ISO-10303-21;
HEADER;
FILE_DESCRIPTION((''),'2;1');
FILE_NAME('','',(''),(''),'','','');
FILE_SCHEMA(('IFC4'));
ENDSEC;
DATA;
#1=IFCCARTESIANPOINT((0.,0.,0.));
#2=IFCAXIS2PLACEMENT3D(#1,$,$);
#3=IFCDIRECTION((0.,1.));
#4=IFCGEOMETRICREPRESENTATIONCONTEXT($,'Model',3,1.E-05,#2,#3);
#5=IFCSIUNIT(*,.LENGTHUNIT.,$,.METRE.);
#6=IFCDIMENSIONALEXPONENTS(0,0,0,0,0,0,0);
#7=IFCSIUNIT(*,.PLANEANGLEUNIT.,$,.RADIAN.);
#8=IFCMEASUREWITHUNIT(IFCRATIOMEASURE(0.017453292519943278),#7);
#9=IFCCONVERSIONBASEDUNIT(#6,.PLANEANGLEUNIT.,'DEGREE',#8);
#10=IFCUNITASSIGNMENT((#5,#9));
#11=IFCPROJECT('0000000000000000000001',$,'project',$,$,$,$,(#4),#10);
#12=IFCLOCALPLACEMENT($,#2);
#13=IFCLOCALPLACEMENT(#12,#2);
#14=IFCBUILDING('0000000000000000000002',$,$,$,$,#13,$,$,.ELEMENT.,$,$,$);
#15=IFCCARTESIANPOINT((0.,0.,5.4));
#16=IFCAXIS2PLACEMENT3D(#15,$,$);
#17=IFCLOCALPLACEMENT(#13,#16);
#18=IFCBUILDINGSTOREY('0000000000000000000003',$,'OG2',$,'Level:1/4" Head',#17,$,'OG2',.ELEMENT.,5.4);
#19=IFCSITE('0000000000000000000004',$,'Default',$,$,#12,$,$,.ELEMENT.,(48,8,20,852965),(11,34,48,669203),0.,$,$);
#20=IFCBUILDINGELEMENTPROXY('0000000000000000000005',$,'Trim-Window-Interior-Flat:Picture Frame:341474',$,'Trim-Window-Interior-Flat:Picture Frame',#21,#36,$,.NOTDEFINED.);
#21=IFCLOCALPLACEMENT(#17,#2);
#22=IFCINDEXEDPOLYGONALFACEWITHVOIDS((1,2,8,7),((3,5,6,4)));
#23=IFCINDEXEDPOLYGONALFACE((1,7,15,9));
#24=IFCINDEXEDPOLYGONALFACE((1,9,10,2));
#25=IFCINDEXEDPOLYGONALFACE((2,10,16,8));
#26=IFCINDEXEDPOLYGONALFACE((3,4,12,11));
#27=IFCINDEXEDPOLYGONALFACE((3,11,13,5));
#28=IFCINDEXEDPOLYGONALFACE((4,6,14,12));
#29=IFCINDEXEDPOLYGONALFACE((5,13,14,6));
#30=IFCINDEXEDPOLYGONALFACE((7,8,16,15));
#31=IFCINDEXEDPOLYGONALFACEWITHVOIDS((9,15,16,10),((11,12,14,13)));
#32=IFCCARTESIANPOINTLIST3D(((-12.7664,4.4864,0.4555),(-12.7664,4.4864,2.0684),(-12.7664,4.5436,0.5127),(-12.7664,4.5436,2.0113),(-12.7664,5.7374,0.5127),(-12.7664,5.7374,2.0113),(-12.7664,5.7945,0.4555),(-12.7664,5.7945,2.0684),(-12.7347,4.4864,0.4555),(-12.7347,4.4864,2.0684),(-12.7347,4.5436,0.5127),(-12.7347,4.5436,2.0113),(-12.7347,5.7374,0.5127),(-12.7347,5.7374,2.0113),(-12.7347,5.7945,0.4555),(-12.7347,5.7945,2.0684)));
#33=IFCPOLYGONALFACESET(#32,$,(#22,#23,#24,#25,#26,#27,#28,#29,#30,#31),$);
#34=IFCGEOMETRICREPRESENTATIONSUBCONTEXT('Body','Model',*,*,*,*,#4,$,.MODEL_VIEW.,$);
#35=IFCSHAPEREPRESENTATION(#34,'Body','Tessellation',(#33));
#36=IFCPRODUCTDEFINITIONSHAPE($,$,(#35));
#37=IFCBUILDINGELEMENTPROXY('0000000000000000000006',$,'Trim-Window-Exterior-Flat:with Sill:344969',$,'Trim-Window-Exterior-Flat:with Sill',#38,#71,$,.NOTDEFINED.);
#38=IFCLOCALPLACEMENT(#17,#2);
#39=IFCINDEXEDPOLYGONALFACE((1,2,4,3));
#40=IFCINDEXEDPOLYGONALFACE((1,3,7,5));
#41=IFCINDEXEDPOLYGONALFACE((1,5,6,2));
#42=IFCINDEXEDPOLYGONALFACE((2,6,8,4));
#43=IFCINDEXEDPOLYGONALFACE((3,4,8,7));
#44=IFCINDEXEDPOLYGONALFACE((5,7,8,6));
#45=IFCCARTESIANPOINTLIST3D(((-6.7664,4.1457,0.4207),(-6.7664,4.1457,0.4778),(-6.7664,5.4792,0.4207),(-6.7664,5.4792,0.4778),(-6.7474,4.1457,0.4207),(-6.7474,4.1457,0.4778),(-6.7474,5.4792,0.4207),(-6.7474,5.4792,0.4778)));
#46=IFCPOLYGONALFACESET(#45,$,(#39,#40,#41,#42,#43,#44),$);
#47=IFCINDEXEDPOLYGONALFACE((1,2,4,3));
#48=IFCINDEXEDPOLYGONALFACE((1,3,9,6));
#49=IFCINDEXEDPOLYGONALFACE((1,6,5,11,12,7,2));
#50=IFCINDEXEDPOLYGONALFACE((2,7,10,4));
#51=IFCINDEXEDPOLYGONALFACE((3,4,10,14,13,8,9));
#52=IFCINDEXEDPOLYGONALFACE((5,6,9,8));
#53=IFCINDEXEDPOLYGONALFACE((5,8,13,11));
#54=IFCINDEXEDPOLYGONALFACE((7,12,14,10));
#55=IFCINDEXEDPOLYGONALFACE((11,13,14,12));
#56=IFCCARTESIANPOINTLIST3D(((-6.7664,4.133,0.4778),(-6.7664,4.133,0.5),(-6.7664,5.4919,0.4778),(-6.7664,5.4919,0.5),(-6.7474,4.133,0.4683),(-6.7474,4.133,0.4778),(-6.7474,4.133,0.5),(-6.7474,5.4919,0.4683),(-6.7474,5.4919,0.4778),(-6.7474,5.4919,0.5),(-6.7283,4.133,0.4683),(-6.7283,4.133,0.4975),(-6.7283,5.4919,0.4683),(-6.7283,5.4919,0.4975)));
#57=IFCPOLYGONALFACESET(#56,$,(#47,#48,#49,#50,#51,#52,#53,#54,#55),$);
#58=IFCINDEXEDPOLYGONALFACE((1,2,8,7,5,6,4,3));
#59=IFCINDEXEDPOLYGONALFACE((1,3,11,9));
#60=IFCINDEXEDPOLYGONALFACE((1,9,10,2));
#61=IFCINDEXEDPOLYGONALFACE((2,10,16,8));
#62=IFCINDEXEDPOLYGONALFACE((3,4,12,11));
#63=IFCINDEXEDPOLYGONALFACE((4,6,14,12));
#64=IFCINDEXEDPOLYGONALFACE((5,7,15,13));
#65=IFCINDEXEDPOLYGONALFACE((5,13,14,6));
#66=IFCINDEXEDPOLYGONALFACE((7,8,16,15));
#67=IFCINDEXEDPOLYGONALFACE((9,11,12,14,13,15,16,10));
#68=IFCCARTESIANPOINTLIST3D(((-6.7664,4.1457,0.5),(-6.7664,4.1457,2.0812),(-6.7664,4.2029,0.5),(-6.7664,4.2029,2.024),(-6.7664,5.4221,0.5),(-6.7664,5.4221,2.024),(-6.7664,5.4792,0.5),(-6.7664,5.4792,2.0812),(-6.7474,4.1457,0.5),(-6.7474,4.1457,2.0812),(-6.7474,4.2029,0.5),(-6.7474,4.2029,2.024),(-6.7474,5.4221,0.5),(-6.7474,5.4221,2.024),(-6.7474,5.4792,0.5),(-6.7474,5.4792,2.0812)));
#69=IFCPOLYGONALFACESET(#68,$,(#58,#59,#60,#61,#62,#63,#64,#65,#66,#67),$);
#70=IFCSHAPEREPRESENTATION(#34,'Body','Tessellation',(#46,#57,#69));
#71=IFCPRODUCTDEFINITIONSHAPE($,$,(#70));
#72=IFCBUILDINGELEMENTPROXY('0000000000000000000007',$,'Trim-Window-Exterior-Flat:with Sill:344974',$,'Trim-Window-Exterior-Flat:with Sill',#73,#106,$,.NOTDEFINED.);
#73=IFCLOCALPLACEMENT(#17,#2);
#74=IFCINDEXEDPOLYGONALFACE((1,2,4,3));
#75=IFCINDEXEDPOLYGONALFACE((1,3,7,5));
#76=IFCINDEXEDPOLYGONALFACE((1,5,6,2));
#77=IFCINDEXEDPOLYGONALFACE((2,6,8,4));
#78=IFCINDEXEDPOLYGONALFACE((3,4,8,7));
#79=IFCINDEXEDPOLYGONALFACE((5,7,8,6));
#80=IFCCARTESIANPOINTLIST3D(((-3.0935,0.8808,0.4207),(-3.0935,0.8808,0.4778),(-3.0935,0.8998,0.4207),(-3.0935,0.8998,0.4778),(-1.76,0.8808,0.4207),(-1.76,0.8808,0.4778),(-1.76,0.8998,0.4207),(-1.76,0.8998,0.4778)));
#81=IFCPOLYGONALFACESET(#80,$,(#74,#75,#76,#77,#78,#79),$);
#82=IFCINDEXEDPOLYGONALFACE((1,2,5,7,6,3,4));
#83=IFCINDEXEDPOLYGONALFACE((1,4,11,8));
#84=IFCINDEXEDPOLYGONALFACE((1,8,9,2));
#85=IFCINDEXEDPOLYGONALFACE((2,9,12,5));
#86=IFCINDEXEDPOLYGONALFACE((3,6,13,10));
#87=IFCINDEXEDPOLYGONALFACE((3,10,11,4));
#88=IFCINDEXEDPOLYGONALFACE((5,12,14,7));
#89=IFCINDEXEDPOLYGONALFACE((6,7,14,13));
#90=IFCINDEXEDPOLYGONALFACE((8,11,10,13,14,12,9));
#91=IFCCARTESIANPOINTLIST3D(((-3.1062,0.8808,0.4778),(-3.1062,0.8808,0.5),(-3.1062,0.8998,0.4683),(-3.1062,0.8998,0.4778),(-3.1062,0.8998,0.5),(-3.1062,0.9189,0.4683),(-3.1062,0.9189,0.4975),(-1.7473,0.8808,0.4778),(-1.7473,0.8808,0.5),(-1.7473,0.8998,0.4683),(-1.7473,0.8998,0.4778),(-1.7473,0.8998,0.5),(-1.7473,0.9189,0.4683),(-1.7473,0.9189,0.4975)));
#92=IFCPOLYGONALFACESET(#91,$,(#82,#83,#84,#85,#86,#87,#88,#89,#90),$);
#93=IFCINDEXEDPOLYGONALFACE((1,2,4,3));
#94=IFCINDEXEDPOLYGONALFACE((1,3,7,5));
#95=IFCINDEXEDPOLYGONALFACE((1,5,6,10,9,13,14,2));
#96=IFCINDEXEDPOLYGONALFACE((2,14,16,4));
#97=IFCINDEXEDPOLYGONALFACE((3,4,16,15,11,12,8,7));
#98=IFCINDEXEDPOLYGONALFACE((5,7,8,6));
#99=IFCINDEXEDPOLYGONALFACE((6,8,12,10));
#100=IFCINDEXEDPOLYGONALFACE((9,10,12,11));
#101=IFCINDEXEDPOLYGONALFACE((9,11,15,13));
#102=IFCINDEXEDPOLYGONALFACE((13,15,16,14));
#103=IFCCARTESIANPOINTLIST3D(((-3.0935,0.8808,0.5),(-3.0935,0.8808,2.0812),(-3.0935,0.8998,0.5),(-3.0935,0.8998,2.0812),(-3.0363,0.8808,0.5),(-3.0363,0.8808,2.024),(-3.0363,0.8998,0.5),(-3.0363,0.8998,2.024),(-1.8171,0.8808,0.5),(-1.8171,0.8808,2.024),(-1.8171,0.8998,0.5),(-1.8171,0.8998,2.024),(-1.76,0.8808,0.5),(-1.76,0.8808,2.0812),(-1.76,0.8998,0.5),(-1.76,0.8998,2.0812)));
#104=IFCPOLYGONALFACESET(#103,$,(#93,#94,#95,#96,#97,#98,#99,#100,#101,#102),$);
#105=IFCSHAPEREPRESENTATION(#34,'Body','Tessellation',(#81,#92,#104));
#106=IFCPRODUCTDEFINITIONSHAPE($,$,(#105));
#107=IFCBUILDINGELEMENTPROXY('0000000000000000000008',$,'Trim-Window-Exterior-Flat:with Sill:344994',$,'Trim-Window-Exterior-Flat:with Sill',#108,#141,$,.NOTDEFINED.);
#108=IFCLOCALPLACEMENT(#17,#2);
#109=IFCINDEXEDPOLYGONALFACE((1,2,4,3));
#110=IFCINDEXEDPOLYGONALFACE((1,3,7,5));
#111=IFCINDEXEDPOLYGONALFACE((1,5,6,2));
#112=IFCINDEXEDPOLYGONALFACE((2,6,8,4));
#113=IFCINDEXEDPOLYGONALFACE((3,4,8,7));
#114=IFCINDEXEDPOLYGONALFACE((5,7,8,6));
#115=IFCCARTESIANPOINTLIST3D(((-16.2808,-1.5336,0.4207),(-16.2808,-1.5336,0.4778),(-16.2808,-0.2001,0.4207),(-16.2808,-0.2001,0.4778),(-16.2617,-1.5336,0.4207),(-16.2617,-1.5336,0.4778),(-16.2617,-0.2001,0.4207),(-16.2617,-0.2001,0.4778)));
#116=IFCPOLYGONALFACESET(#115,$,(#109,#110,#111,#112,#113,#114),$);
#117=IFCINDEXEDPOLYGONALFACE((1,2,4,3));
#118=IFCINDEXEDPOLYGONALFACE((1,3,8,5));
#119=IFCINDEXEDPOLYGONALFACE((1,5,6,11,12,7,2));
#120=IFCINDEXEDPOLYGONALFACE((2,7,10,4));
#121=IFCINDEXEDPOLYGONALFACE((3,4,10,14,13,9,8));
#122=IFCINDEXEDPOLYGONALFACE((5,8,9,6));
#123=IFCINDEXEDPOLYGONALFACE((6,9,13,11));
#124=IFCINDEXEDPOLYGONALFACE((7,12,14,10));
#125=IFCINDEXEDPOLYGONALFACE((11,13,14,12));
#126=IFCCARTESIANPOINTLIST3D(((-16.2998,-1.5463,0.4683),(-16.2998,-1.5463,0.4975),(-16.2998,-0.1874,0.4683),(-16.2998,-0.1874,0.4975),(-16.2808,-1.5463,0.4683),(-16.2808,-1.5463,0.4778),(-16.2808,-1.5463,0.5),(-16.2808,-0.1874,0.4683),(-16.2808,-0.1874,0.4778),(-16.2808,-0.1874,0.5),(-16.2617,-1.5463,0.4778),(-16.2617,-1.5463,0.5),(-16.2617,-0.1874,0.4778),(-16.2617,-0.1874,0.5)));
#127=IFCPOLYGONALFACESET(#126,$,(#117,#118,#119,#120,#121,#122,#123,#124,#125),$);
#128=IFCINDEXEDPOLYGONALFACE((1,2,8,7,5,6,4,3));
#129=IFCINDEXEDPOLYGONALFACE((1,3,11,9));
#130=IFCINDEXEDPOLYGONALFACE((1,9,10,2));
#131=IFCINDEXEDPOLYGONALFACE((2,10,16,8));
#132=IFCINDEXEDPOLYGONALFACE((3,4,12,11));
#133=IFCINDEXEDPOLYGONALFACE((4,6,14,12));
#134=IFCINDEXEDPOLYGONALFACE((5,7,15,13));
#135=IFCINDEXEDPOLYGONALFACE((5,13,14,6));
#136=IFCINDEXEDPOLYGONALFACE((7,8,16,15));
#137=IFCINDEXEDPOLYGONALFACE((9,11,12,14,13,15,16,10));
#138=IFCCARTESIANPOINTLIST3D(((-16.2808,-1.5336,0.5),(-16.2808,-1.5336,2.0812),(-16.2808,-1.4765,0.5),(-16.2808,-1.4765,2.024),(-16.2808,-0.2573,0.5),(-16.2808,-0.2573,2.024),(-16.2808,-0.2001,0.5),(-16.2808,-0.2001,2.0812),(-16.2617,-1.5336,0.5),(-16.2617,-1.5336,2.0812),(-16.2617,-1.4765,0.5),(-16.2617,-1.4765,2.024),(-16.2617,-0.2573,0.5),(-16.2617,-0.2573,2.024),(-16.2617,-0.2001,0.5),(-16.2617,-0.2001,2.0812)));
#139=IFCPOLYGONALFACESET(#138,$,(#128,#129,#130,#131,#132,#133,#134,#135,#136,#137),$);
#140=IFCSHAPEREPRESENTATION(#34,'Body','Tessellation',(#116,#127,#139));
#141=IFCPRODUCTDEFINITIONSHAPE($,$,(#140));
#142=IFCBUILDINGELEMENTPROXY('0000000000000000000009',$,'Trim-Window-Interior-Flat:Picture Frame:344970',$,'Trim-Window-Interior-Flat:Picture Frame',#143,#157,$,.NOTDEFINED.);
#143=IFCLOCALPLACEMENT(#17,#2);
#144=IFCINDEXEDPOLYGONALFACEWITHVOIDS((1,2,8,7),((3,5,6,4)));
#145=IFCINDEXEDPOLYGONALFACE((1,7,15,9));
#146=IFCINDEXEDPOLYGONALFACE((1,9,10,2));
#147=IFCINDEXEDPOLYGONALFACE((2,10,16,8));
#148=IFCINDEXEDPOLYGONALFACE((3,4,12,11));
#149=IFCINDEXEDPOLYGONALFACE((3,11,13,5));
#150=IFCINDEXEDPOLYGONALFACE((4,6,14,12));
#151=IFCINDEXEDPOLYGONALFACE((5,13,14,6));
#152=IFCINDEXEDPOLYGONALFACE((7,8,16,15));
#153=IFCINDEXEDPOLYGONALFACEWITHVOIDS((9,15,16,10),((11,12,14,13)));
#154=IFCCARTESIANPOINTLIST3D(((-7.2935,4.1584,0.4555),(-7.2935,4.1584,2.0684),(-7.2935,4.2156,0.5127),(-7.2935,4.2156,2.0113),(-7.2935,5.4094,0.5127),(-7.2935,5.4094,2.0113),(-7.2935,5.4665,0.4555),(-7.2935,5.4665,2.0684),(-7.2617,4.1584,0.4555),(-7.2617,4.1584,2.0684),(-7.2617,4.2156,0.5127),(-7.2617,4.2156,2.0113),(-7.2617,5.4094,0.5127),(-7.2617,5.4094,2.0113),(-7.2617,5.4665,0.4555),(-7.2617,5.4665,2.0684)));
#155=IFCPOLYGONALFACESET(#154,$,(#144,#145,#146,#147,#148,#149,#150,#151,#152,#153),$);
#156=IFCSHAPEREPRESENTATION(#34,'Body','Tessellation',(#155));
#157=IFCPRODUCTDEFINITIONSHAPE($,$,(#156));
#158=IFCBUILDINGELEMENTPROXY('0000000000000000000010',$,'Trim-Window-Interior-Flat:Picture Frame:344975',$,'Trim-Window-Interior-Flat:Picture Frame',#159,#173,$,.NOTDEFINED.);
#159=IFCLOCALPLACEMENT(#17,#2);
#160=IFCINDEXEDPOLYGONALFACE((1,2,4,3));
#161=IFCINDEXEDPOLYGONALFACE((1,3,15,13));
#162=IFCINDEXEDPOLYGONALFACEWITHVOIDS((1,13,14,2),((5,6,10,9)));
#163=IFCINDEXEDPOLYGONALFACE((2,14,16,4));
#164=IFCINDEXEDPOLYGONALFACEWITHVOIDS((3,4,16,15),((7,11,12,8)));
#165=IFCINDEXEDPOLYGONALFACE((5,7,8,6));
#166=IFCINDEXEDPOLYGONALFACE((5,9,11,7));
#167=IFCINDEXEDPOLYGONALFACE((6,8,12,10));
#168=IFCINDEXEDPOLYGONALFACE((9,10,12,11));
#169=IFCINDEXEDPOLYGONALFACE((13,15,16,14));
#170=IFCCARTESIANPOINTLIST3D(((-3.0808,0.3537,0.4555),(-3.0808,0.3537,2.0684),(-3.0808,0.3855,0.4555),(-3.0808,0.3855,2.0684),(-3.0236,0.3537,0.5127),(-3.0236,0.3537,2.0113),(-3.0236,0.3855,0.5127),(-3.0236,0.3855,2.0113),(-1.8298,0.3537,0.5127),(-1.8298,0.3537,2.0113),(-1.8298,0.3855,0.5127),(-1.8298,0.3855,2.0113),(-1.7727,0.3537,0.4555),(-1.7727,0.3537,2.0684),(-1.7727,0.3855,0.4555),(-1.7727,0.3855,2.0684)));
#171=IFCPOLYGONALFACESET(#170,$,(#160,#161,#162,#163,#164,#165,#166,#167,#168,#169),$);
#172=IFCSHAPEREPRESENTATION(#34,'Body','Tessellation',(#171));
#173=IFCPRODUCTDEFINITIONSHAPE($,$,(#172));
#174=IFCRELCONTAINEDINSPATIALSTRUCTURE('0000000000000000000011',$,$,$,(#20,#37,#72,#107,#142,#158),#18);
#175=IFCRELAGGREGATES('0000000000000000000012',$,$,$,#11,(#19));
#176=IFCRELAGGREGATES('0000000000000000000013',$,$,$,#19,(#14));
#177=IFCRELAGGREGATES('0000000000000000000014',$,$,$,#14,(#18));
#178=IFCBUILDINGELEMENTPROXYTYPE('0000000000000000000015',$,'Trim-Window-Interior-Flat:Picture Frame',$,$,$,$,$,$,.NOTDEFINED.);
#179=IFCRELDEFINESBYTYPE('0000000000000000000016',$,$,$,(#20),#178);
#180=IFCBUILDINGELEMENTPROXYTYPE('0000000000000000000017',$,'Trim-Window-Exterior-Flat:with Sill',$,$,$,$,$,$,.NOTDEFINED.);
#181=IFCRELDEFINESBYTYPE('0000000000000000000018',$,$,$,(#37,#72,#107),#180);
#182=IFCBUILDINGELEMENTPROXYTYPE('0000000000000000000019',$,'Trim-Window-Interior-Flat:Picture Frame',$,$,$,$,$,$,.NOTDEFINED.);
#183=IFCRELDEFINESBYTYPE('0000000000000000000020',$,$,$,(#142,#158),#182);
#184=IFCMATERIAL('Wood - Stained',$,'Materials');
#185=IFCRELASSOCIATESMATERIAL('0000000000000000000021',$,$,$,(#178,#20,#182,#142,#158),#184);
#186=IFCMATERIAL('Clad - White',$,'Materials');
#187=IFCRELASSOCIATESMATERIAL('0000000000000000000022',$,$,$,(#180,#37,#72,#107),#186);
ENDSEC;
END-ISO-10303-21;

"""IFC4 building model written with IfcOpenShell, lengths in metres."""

from ifc_helpers import new_model, entity, si_unit, converted_unit, direction, frame, origin, place, context, subcontext, project, spatial, indexed_curve, outline, extrude, source, transform, mapped, material, type_object, type_shapes, element, save


model = new_model("IFC4")

# Units and contexts
model_context = context("Model", 3, precision=1e-05, world=origin(), true_north=direction((0.0, 1.0)))
body_context = subcontext(model_context, "Body", "Model", "MODEL_VIEW")
ifc_project = project(units=[si_unit("LENGTHUNIT", "METRE"), converted_unit("PLANEANGLEUNIT", "DEGREE", entity("IfcRatioMeasure", 0.017453292519943278), si_unit("PLANEANGLEUNIT", "RADIAN"), dimensions=[0, 0, 0, 0, 0, 0, 0])], contexts=[model_context])

# Site, building, storey
site_placement = place(None, origin())
site = spatial("IfcSite", under=ifc_project, at=site_placement, Name="Default", CompositionType="ELEMENT", RefLatitude=(48, 8, 20, 852965), RefLongitude=(11, 34, 48, 669203), RefElevation=0.0)
building_placement = place(site_placement, origin())
building = spatial("IfcBuilding", under=site, at=building_placement, CompositionType="ELEMENT")
storey_placement = place(building_placement, frame((0.0, 0.0, 5.4)))
storey = spatial("IfcBuildingStorey", under=building, at=storey_placement, Name="OG2", ObjectType="Level:1/4\" Head", LongName="OG2", CompositionType="ELEMENT", Elevation=5.4)

# Building element proxies
ifc_material_1 = material(Name="Clad - White", Category="Materials")
ifc_material_2 = material(Name="Wood - Stained", Category="Materials")
building_element_proxy_type_1 = type_object("IfcBuildingElementProxyType", Name="Trim-Window-Interior-Flat:Picture Frame", PredefinedType="NOTDEFINED", material=ifc_material_2)
shared_shape_1 = source(origin(), body_context, "Body", "SweptSolid", [
    extrude(outline(indexed_curve([(-0.8064, -0.654), (0.8064, -0.654), (0.8064, 0.654), (-0.8064, 0.654), (-0.8064, -0.654)], self_intersect=False), holes=[indexed_curve([(-0.7493, -0.5969), (-0.7493, 0.5969), (0.7493, 0.5969), (0.7493, -0.5969), (-0.7493, -0.5969)], self_intersect=False)]), frame((0.0, 0.762, 0.0), z_axis=(0.0, 0.0, 1.0), x_axis=(0.0, 1.0, 0.0)), (0.0, 0.0, 1.0), 0.0317),
])
type_shapes(building_element_proxy_type_1, [shared_shape_1])
for number, where, z_axis, x_axis, name in (
    (1, (-12.7664, 5.1405, 2.024), (1.0, 0.0, 0.0), (0.0, -1.0, 0.0), "Trim-Window-Interior-Flat:Picture Frame:341474"),
):
    element("IfcBuildingElementProxy", number, at=place(storey_placement, frame(where, z_axis=z_axis, x_axis=x_axis)), inside=storey, type_object=building_element_proxy_type_1, material=ifc_material_2, Name=name, ObjectType="Trim-Window-Interior-Flat:Picture Frame", PredefinedType="NOTDEFINED", context=body_context, shape_type="MappedRepresentation", body=[
        mapped(shared_shape_1, transform((0.0, 0.0, 0.0), scale=1.0)),
    ])
building_element_proxy_type_2 = type_object("IfcBuildingElementProxyType", Name="Trim-Window-Exterior-Flat:with Sill", PredefinedType="NOTDEFINED", material=ifc_material_1)
shared_shape_2 = source(origin(), body_context, "Body", "SweptSolid", [
    extrude(outline(indexed_curve([(-0.6667, -0.0286), (0.6667, -0.0286), (0.6667, 0.0286), (-0.6667, 0.0286), (-0.6667, -0.0286)], self_intersect=False)), frame((0.0, -1.5748, 0.0), z_axis=(0.0, 0.0, 1.0), x_axis=(-1.0, 0.0, 0.0)), (0.0, 0.0, 1.0), 0.019),
    extrude(outline(indexed_curve([(-0.019, -0.016), (0.0, -0.016), (0.0, -0.0064), (0.019, -0.0064), (0.019, 0.0158), (0.0, 0.0158), (-0.019, 0.0133), (-0.019, -0.016)], self_intersect=False)), frame((-0.6794, -1.5398, 0.019), z_axis=(1.0, 0.0, 0.0), x_axis=(0.0, 0.0, -1.0)), (0.0, 0.0, 1.0), 1.3589),
    extrude(outline(indexed_curve([(-0.8049, -0.6667), (0.7763, -0.6667), (0.7763, -0.6096), (-0.7477, -0.6096), (-0.7477, 0.6096), (0.7763, 0.6096), (0.7763, 0.6667), (-0.8049, 0.6667), (-0.8049, -0.6667)], self_intersect=False)), frame((0.0, -0.7477, 0.0), z_axis=(0.0, 0.0, 1.0), x_axis=(0.0, -1.0, 0.0)), (0.0, 0.0, 1.0), 0.019),
])
type_shapes(building_element_proxy_type_2, [shared_shape_2])
for number, where, z_axis, x_axis, name in (
    (2, (-6.7664, 4.8125, 2.024), (1.0, 0.0, 0.0), (0.0, 1.0, 0.0), "Trim-Window-Exterior-Flat:with Sill:344969"),
    (3, (-2.4267, 0.8808, 2.024), (0.0, 1.0, 0.0), (-1.0, 0.0, 0.0), "Trim-Window-Exterior-Flat:with Sill:344974"),
    (4, (-16.2617, -0.8669, 2.024), (-1.0, 0.0, 0.0), (0.0, -1.0, 0.0), "Trim-Window-Exterior-Flat:with Sill:344994"),
):
    element("IfcBuildingElementProxy", number, at=place(storey_placement, frame(where, z_axis=z_axis, x_axis=x_axis)), inside=storey, type_object=building_element_proxy_type_2, material=ifc_material_1, Name=name, ObjectType="Trim-Window-Exterior-Flat:with Sill", PredefinedType="NOTDEFINED", context=body_context, shape_type="MappedRepresentation", body=[
        mapped(shared_shape_2, transform((0.0, 0.0, 0.0), scale=1.0)),
    ])
building_element_proxy_type_3 = type_object("IfcBuildingElementProxyType", Name="Trim-Window-Interior-Flat:Picture Frame", PredefinedType="NOTDEFINED", material=ifc_material_2)
shared_shape_3 = source(origin(), body_context, "Body", "SweptSolid", [
    extrude(outline(indexed_curve([(-0.654, -0.8064), (0.654, -0.8064), (0.654, 0.8064), (-0.654, 0.8064), (-0.654, -0.8064)], self_intersect=False), holes=[indexed_curve([(-0.5969, -0.7493), (-0.5969, 0.7493), (0.5969, 0.7493), (0.5969, -0.7493), (-0.5969, -0.7493)], self_intersect=False)]), frame((0.0, -0.762, 0.0), z_axis=(0.0, 0.0, 1.0), x_axis=(-1.0, 0.0, 0.0)), (0.0, 0.0, 1.0), 0.0317),
])
type_shapes(building_element_proxy_type_3, [shared_shape_3])
for number, where, z_axis, x_axis, name in (
    (5, (-7.2617, 4.8125, 2.024), (-1.0, 0.0, 0.0), (0.0, -1.0, 0.0), "Trim-Window-Interior-Flat:Picture Frame:344970"),
    (6, (-2.4267, 0.3855, 2.024), (0.0, -1.0, 0.0), (1.0, 0.0, 0.0), "Trim-Window-Interior-Flat:Picture Frame:344975"),
):
    element("IfcBuildingElementProxy", number, at=place(storey_placement, frame(where, z_axis=z_axis, x_axis=x_axis)), inside=storey, type_object=building_element_proxy_type_3, material=ifc_material_2, Name=name, ObjectType="Trim-Window-Interior-Flat:Picture Frame", PredefinedType="NOTDEFINED", context=body_context, shape_type="MappedRepresentation", body=[
        mapped(shared_shape_3, transform((0.0, 0.0, 0.0), scale=1.0)),
    ])

save(model, "model.ifc")
